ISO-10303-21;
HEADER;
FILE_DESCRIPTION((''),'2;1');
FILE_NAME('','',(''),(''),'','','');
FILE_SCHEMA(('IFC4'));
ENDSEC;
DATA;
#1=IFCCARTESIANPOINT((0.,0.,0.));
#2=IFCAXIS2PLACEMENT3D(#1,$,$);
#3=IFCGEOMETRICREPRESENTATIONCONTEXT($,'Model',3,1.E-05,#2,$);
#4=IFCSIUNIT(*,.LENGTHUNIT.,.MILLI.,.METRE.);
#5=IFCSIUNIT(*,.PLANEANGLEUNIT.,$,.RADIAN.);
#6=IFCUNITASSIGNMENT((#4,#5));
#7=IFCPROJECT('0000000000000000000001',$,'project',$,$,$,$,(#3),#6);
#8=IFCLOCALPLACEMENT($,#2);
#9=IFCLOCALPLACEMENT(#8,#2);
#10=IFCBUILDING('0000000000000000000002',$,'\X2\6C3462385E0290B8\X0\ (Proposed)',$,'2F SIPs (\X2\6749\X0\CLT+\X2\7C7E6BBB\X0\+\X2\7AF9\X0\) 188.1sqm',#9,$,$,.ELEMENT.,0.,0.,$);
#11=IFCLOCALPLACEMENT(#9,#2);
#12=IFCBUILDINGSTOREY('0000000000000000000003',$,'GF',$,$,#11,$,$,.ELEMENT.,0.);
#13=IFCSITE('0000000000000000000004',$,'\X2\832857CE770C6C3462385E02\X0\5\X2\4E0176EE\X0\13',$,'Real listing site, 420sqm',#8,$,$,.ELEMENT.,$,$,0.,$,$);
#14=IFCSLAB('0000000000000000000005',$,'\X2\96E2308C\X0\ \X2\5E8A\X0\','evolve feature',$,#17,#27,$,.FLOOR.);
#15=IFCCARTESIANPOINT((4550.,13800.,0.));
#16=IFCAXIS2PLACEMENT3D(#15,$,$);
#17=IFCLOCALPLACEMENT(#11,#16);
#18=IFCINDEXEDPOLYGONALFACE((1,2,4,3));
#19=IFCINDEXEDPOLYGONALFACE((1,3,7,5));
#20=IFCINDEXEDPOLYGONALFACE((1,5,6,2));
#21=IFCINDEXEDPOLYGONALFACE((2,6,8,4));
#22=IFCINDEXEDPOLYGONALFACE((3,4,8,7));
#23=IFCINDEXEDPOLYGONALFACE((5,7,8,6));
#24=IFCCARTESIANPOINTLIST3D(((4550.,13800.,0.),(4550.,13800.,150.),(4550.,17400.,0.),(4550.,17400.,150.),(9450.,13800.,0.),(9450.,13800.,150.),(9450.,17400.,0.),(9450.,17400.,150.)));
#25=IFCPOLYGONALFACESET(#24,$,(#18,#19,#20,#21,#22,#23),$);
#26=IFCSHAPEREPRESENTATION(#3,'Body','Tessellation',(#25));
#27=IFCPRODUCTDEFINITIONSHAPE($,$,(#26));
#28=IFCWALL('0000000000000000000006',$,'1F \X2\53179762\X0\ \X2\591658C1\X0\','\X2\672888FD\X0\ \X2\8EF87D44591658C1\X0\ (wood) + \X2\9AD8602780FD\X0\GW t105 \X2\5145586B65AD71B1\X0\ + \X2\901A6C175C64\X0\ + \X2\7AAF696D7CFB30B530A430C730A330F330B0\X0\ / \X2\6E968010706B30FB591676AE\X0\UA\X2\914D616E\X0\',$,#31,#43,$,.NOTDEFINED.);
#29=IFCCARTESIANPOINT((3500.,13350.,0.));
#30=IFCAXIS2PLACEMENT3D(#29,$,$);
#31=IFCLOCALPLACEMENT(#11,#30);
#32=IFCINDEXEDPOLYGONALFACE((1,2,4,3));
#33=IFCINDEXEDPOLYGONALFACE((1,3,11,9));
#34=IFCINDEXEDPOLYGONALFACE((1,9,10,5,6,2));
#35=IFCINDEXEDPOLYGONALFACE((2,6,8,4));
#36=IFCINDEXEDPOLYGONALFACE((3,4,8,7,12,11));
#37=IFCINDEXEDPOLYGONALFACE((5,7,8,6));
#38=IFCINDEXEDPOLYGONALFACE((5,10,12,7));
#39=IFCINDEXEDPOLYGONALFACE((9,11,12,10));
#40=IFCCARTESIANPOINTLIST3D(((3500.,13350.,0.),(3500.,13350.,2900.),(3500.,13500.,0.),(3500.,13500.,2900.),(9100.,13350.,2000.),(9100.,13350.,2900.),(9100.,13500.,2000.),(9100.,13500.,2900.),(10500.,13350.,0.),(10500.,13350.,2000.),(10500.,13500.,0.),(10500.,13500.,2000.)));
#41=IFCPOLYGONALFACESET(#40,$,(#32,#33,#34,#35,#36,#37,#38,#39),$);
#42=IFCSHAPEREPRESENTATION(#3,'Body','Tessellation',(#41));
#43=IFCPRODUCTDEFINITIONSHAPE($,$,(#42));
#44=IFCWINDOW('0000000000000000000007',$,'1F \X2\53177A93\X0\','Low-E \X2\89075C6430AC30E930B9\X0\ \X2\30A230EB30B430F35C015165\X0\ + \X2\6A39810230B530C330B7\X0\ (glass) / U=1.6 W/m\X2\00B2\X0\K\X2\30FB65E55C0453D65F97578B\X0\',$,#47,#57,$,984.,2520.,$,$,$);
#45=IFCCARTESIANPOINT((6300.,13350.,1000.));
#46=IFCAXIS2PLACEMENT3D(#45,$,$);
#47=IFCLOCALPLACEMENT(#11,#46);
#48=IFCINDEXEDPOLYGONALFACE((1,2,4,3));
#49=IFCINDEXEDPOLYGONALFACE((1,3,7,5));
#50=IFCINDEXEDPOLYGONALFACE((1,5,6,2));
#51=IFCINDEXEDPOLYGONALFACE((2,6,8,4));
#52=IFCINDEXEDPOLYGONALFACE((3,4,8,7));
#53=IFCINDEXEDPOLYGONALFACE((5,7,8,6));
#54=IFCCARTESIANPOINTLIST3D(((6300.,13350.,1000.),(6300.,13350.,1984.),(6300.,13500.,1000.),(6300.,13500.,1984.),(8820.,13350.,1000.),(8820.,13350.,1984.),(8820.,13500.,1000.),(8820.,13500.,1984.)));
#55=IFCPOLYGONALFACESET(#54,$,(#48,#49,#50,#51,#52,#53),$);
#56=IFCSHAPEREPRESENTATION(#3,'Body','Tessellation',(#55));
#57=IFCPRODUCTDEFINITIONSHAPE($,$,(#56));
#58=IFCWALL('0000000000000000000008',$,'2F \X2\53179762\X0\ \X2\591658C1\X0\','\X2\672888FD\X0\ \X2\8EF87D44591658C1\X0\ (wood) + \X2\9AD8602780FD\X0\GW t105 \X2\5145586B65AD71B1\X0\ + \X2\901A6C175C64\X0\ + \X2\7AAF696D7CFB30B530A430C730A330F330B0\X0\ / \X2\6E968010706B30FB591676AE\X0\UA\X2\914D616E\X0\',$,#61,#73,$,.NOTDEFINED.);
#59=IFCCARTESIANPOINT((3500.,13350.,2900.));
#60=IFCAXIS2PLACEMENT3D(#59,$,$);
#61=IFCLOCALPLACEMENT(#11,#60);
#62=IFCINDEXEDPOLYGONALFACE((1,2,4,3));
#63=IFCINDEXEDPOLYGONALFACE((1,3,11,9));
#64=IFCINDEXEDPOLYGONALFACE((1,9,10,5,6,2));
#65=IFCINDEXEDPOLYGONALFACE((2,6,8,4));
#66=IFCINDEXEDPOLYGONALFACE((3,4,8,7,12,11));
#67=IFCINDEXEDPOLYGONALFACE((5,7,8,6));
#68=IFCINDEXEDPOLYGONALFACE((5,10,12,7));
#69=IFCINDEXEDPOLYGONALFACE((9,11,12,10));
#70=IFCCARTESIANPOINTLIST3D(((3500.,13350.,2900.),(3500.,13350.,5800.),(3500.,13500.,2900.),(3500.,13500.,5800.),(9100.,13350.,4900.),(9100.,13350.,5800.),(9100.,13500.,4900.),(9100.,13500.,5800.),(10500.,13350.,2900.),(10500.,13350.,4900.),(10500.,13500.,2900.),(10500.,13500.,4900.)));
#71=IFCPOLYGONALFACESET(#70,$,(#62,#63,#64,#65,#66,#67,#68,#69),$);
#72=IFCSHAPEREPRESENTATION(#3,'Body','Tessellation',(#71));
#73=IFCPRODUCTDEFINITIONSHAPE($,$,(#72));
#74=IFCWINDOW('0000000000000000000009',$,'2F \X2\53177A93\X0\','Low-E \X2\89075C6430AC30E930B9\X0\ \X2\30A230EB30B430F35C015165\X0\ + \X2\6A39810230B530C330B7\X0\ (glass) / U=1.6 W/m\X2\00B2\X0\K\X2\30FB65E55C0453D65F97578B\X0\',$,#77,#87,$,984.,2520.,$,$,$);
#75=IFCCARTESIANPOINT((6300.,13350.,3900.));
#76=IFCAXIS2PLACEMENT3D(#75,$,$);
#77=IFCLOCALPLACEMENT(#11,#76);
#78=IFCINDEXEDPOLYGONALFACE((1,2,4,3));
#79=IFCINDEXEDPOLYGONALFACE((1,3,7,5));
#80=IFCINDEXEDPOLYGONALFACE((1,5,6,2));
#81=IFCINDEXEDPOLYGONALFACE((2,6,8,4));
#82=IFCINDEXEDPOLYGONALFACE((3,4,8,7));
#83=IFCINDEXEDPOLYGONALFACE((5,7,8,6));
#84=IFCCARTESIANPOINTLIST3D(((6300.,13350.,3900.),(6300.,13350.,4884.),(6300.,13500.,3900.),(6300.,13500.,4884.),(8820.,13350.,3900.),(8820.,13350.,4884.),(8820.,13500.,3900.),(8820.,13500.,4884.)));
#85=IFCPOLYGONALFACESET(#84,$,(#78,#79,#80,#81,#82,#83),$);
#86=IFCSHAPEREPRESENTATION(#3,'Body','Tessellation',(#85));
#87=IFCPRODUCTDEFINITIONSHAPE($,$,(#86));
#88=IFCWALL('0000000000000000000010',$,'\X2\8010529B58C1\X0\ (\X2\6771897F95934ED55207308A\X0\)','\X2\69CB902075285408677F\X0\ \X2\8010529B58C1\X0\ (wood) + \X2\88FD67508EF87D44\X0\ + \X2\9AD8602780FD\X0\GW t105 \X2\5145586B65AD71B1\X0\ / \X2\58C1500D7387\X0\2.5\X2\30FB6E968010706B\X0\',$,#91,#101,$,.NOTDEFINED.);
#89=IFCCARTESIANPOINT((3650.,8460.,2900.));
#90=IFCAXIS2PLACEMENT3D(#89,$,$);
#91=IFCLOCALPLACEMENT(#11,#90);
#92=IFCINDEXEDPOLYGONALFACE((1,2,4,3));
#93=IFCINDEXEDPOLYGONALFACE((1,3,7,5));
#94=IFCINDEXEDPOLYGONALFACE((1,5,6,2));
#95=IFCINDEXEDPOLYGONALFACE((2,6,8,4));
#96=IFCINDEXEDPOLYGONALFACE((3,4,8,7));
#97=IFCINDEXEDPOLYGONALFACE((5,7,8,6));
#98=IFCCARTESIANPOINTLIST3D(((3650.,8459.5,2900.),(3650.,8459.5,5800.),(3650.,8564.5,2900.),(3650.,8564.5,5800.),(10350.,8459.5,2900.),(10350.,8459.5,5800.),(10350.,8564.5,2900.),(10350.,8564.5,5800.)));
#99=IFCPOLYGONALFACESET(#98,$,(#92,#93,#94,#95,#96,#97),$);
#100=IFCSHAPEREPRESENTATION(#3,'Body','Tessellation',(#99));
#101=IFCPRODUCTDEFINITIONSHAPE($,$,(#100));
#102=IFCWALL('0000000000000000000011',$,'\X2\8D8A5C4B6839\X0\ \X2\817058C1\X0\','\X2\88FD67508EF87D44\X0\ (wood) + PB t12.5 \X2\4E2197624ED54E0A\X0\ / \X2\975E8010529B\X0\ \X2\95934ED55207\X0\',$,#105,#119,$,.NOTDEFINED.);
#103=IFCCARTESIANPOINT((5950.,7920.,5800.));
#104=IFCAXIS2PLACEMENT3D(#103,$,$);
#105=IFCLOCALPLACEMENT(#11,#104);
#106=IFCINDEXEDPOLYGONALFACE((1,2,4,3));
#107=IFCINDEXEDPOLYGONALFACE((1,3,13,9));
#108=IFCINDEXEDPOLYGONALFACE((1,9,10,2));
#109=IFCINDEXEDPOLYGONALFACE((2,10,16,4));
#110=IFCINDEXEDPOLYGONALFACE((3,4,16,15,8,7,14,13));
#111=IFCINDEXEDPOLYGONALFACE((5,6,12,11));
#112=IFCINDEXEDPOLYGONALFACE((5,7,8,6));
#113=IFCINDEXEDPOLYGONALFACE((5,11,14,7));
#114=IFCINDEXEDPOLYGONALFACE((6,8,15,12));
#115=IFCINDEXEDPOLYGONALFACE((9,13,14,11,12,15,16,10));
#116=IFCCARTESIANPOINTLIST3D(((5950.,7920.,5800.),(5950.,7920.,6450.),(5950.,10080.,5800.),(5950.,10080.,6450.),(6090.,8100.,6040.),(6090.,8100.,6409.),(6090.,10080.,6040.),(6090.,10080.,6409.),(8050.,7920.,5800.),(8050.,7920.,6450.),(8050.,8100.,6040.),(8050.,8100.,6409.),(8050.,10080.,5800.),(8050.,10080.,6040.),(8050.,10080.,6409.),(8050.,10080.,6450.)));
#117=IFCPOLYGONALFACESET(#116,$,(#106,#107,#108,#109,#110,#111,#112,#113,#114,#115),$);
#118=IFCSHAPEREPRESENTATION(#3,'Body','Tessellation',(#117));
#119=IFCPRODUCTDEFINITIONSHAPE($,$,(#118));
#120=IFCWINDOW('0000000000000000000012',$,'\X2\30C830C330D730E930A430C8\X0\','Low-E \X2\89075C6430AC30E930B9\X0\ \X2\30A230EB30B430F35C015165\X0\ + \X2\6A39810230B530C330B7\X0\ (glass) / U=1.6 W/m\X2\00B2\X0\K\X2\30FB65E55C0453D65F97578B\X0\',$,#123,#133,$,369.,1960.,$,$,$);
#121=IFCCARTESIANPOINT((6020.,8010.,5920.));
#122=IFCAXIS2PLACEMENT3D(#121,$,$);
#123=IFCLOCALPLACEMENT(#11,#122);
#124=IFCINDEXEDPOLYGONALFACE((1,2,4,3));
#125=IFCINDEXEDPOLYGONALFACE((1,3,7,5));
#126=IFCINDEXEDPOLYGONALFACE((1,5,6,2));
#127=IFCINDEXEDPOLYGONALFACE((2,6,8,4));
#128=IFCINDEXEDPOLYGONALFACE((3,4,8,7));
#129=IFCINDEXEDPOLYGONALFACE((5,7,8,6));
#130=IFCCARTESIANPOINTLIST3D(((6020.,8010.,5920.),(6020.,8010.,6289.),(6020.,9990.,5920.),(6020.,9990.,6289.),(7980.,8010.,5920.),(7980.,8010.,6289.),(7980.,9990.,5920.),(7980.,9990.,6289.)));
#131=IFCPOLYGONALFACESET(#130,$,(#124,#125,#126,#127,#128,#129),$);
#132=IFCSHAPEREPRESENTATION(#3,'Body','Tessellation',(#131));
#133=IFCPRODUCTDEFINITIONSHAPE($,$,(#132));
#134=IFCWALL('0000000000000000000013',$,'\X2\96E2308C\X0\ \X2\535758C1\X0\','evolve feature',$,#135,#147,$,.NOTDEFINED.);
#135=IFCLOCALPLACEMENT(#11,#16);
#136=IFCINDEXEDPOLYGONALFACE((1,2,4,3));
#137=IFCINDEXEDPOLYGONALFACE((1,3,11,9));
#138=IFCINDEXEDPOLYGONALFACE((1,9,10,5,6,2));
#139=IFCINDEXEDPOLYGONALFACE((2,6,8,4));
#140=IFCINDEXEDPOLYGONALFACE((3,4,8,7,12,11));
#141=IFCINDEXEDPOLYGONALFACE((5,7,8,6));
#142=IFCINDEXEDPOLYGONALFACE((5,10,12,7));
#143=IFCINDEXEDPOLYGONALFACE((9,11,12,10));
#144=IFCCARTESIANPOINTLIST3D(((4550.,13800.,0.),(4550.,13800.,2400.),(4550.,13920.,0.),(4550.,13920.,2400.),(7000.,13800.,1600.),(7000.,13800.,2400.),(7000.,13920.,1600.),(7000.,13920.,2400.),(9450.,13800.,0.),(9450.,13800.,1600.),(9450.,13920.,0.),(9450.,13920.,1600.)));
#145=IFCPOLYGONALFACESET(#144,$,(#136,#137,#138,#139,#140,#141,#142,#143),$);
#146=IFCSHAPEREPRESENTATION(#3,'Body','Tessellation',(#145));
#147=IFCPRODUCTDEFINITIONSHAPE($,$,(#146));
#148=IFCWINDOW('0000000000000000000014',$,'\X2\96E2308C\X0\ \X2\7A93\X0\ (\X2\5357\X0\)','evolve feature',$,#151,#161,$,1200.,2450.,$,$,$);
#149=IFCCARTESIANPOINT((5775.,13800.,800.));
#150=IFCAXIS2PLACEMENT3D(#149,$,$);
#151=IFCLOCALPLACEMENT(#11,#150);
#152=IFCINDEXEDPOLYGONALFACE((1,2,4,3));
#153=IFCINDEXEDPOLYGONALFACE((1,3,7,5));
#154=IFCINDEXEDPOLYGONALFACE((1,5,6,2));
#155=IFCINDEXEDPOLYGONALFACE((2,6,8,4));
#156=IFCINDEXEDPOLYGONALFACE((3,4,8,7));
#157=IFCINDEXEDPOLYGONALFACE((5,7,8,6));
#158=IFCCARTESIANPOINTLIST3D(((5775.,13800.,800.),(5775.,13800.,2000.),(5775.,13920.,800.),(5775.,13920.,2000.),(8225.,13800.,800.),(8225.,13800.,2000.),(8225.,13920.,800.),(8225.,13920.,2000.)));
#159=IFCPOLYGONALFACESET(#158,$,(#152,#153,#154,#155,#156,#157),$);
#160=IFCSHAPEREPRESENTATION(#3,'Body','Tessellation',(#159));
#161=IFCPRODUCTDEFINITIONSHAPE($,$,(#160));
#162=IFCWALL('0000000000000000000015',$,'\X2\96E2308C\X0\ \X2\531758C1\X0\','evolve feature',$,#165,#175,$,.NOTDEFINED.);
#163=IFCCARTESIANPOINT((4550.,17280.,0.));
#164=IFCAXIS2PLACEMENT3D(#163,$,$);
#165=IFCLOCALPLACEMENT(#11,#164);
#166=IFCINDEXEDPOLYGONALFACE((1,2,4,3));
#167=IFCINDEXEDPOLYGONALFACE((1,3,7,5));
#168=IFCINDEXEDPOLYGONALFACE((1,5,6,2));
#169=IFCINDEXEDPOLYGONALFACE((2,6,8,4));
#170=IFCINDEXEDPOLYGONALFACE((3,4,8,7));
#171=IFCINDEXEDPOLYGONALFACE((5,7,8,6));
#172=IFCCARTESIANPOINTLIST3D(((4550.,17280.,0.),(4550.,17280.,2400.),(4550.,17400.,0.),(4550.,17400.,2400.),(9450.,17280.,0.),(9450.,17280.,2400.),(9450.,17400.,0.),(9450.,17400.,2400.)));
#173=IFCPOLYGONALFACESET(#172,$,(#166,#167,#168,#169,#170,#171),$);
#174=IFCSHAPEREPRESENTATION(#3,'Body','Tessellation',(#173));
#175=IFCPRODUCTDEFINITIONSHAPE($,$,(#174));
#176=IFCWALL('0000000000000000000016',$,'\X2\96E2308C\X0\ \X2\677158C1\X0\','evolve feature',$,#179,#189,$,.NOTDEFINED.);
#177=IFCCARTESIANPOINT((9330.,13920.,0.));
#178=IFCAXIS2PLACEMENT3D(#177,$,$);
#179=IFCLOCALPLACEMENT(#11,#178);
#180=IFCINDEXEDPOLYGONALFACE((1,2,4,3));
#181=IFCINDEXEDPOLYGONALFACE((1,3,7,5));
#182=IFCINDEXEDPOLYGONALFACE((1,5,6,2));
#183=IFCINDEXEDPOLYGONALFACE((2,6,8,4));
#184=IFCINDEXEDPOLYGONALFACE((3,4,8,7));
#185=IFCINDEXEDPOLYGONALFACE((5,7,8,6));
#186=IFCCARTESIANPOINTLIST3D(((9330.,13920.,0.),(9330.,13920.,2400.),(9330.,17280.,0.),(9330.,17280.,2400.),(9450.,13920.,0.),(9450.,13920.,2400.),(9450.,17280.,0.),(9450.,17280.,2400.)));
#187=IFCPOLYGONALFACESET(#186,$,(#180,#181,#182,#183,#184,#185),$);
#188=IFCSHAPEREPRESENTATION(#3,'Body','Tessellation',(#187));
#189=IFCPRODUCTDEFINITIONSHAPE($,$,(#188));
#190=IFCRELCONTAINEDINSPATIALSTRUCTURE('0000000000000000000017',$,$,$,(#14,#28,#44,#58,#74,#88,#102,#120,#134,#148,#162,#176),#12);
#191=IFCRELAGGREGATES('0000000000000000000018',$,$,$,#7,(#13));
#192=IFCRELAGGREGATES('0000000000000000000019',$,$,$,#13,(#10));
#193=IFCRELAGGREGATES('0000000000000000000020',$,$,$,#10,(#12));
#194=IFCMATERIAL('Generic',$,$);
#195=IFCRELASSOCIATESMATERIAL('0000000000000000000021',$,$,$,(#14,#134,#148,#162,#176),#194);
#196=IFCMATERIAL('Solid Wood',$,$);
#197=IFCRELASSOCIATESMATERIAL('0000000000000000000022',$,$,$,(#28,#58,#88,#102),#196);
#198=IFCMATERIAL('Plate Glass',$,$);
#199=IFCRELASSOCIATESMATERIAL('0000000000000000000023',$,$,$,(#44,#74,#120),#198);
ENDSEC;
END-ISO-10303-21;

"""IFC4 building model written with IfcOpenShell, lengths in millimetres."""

from ifc_helpers import new_model, si_unit, frame, frame_2d, origin, place, context, project, spatial, rectangle, extrude, material, element, fill, save


model = new_model("IFC4")

# Units and contexts
model_context = context("Model", 3, precision=1e-05, world=origin())
ifc_project = project(units=[si_unit("LENGTHUNIT", "METRE", prefix="MILLI"), si_unit("PLANEANGLEUNIT", "RADIAN")], contexts=[model_context])

# Site, building, storey
site_placement = place(None, origin())
site = spatial("IfcSite", under=ifc_project, at=site_placement, Name="茨城県水戸市5丁目13", ObjectType="Real listing site, 420sqm", CompositionType="ELEMENT", RefElevation=0.0)
building_placement = place(site_placement, origin())
building = spatial("IfcBuilding", under=site, at=building_placement, Name="水戸市邸 (Proposed)", ObjectType="2F SIPs (杉CLT+籾殻+竹) 188.1sqm", CompositionType="ELEMENT", ElevationOfRefHeight=0.0, ElevationOfTerrain=0.0)
storey_placement = place(building_placement, origin())
storey = spatial("IfcBuildingStorey", under=building, at=storey_placement, Name="GF", CompositionType="ELEMENT", Elevation=0.0)

# Slab
ifc_material_1 = material(Name="Generic")
slab_placement = place(storey_placement, frame((4550.0, 13800.0, 0.0)))
element("IfcSlab", 1, at=slab_placement, inside=storey, material=ifc_material_1, Name="離れ 床", Description="evolve feature", PredefinedType="FLOOR", context=model_context, shape_type="SweptSolid", body=[
    extrude(rectangle(XDim=4900.0, YDim=3600.0, at=frame_2d((2450.0, 1800.0))), frame((4550.0, 13800.0, 0.0)), (0.0, 0.0, 1.0), 150.0),
])

# Wall, opening, window
ifc_material_2 = material(Name="Solid Wood")
wall_1_placement = place(storey_placement, frame((3500.0, 13350.0, 0.0)))
wall_1 = element("IfcWall", 2, at=wall_1_placement, inside=storey, material=ifc_material_2, Name="1F 北面 外壁", Description="木製 軸組外壁 (wood) + 高性能GW t105 充填断熱 + 通気層 + 窯業系サイディング / 準耐火・外皮UA配慮", PredefinedType="NOTDEFINED", context=model_context, shape_type="SweptSolid", body=[
    extrude(rectangle(XDim=7000.0, YDim=150.0, at=frame_2d((3500.0, 75.0))), frame((3500.0, 13350.0, 0.0)), (0.0, 0.0, 1.0), 2900.0),
])
opening_1_placement = place(storey_placement, frame((6300.0, 13350.0, 1000.0)))
opening_1 = element("IfcOpeningElement", 3, at=opening_1_placement, cuts=wall_1, PredefinedType="NOTDEFINED", context=model_context, shape_type="SweptSolid", body=[
    extrude(rectangle(XDim=2520.0, YDim=150.0, at=frame_2d((1260.0, 75.0))), frame((6300.0, 13350.0, 1000.0)), (0.0, 0.0, 1.0), 984.0),
])
ifc_material_3 = material(Name="Plate Glass")
window_1_placement = place(storey_placement, frame((6300.0, 13350.0, 1000.0)))
window_1 = element("IfcWindow", 4, at=window_1_placement, inside=storey, material=ifc_material_3, Name="1F 北窓", Description="Low-E 複層ガラス アルゴン封入 + 樹脂サッシ (glass) / U=1.6 W/m²K・日射取得型", OverallHeight=984.0, OverallWidth=2520.0, context=model_context, shape_type="SweptSolid", body=[
    extrude(rectangle(XDim=2520.0, YDim=150.0, at=frame_2d((1260.0, 75.0))), frame((6300.0, 13350.0, 1000.0)), (0.0, 0.0, 1.0), 984.0),
])
fill(opening_1, window_1)

# Wall, opening, window
wall_2_placement = place(storey_placement, frame((3500.0, 13350.0, 2900.0)))
wall_2 = element("IfcWall", 5, at=wall_2_placement, inside=storey, material=ifc_material_2, Name="2F 北面 外壁", Description="木製 軸組外壁 (wood) + 高性能GW t105 充填断熱 + 通気層 + 窯業系サイディング / 準耐火・外皮UA配慮", PredefinedType="NOTDEFINED", context=model_context, shape_type="SweptSolid", body=[
    extrude(rectangle(XDim=7000.0, YDim=150.0, at=frame_2d((3500.0, 75.0))), frame((3500.0, 13350.0, 2900.0)), (0.0, 0.0, 1.0), 2900.0),
])
opening_2_placement = place(storey_placement, frame((6300.0, 13350.0, 3900.0)))
opening_2 = element("IfcOpeningElement", 6, at=opening_2_placement, cuts=wall_2, PredefinedType="NOTDEFINED", context=model_context, shape_type="SweptSolid", body=[
    extrude(rectangle(XDim=2520.0, YDim=150.0, at=frame_2d((1260.0, 75.0))), frame((6300.0, 13350.0, 3900.0)), (0.0, 0.0, 1.0), 984.0),
])
window_2_placement = place(storey_placement, frame((6300.0, 13350.0, 3900.0)))
window_2 = element("IfcWindow", 7, at=window_2_placement, inside=storey, material=ifc_material_3, Name="2F 北窓", Description="Low-E 複層ガラス アルゴン封入 + 樹脂サッシ (glass) / U=1.6 W/m²K・日射取得型", OverallHeight=984.0, OverallWidth=2520.0, context=model_context, shape_type="SweptSolid", body=[
    extrude(rectangle(XDim=2520.0, YDim=150.0, at=frame_2d((1260.0, 75.0))), frame((6300.0, 13350.0, 3900.0)), (0.0, 0.0, 1.0), 984.0),
])
fill(opening_2, window_2)

# Wall
wall_3_placement = place(storey_placement, frame((3650.0, 8460.0, 2900.0)))
element("IfcWall", 8, at=wall_3_placement, inside=storey, material=ifc_material_2, Name="耐力壁 (東西間仕切り)", Description="構造用合板 耐力壁 (wood) + 製材軸組 + 高性能GW t105 充填断熱 / 壁倍率2.5・準耐火", PredefinedType="NOTDEFINED", context=model_context, shape_type="SweptSolid", body=[
    extrude(rectangle(XDim=6700.0, YDim=105.0, at=frame_2d((3350.0, 52.0))), frame((3650.0, 8460.0, 2900.0)), (0.0, 0.0, 1.0), 2900.0),
])

# Walls, openings, windows
wall_4_placement = place(storey_placement, frame((5950.0, 7920.0, 5800.0)))
wall_4 = element("IfcWall", 9, at=wall_4_placement, inside=storey, material=ifc_material_2, Name="越屋根 腰壁", Description="製材軸組 (wood) + PB t12.5 両面仕上 / 非耐力 間仕切", PredefinedType="NOTDEFINED", context=model_context, shape_type="SweptSolid", body=[
    extrude(rectangle(XDim=2100.0, YDim=2160.0, at=frame_2d((1050.0, 1080.0))), frame((5950.0, 7920.0, 5800.0)), (0.0, 0.0, 1.0), 650.0),
])
opening_3_placement = place(storey_placement, frame((6020.0, 8010.0, 5920.0)))
opening_3 = element("IfcOpeningElement", 10, at=opening_3_placement, cuts=wall_4, PredefinedType="NOTDEFINED", context=model_context, shape_type="SweptSolid", body=[
    extrude(rectangle(XDim=1960.0, YDim=1980.0, at=frame_2d((980.0, 990.0))), frame((6020.0, 8010.0, 5920.0)), (0.0, 0.0, 1.0), 369.0),
])
window_3_placement = place(storey_placement, frame((6020.0, 8010.0, 5920.0)))
window_3 = element("IfcWindow", 11, at=window_3_placement, inside=storey, material=ifc_material_3, Name="トップライト", Description="Low-E 複層ガラス アルゴン封入 + 樹脂サッシ (glass) / U=1.6 W/m²K・日射取得型", OverallHeight=369.0, OverallWidth=1960.0, context=model_context, shape_type="SweptSolid", body=[
    extrude(rectangle(XDim=1960.0, YDim=1980.0, at=frame_2d((980.0, 990.0))), frame((6020.0, 8010.0, 5920.0)), (0.0, 0.0, 1.0), 369.0),
])
fill(opening_3, window_3)
wall_5_placement = place(storey_placement, frame((4550.0, 13800.0, 0.0)))
wall_5 = element("IfcWall", 12, at=wall_5_placement, inside=storey, material=ifc_material_1, Name="離れ 南壁", Description="evolve feature", PredefinedType="NOTDEFINED", context=model_context, shape_type="SweptSolid", body=[
    extrude(rectangle(XDim=4900.0, YDim=120.0, at=frame_2d((2450.0, 60.0))), frame((4550.0, 13800.0, 0.0)), (0.0, 0.0, 1.0), 2400.0),
])
opening_4_placement = place(storey_placement, frame((5775.0, 13800.0, 800.0)))
opening_4 = element("IfcOpeningElement", 13, at=opening_4_placement, cuts=wall_5, PredefinedType="NOTDEFINED", context=model_context, shape_type="SweptSolid", body=[
    extrude(rectangle(XDim=2450.0, YDim=120.0, at=frame_2d((1225.0, 60.0))), frame((5775.0, 13800.0, 800.0)), (0.0, 0.0, 1.0), 1200.0),
])
window_4_placement = place(storey_placement, frame((5775.0, 13800.0, 800.0)))
window_4 = element("IfcWindow", 14, at=window_4_placement, inside=storey, material=ifc_material_1, Name="離れ 窓 (南)", Description="evolve feature", OverallHeight=1200.0, OverallWidth=2450.0, context=model_context, shape_type="SweptSolid", body=[
    extrude(rectangle(XDim=2450.0, YDim=120.0, at=frame_2d((1225.0, 60.0))), frame((5775.0, 13800.0, 800.0)), (0.0, 0.0, 1.0), 1200.0),
])
fill(opening_4, window_4)

# Walls
wall_6_placement = place(storey_placement, frame((4550.0, 17280.0, 0.0)))
element("IfcWall", 15, at=wall_6_placement, inside=storey, material=ifc_material_1, Name="離れ 北壁", Description="evolve feature", PredefinedType="NOTDEFINED", context=model_context, shape_type="SweptSolid", body=[
    extrude(rectangle(XDim=4900.0, YDim=120.0, at=frame_2d((2450.0, 60.0))), frame((4550.0, 17280.0, 0.0)), (0.0, 0.0, 1.0), 2400.0),
])
wall_7_placement = place(storey_placement, frame((9330.0, 13920.0, 0.0)))
element("IfcWall", 16, at=wall_7_placement, inside=storey, material=ifc_material_1, Name="離れ 東壁", Description="evolve feature", PredefinedType="NOTDEFINED", context=model_context, shape_type="SweptSolid", body=[
    extrude(rectangle(XDim=120.0, YDim=3360.0, at=frame_2d((60.0, 1680.0))), frame((9330.0, 13920.0, 0.0)), (0.0, 0.0, 1.0), 2400.0),
])

save(model, "model.ifc")
